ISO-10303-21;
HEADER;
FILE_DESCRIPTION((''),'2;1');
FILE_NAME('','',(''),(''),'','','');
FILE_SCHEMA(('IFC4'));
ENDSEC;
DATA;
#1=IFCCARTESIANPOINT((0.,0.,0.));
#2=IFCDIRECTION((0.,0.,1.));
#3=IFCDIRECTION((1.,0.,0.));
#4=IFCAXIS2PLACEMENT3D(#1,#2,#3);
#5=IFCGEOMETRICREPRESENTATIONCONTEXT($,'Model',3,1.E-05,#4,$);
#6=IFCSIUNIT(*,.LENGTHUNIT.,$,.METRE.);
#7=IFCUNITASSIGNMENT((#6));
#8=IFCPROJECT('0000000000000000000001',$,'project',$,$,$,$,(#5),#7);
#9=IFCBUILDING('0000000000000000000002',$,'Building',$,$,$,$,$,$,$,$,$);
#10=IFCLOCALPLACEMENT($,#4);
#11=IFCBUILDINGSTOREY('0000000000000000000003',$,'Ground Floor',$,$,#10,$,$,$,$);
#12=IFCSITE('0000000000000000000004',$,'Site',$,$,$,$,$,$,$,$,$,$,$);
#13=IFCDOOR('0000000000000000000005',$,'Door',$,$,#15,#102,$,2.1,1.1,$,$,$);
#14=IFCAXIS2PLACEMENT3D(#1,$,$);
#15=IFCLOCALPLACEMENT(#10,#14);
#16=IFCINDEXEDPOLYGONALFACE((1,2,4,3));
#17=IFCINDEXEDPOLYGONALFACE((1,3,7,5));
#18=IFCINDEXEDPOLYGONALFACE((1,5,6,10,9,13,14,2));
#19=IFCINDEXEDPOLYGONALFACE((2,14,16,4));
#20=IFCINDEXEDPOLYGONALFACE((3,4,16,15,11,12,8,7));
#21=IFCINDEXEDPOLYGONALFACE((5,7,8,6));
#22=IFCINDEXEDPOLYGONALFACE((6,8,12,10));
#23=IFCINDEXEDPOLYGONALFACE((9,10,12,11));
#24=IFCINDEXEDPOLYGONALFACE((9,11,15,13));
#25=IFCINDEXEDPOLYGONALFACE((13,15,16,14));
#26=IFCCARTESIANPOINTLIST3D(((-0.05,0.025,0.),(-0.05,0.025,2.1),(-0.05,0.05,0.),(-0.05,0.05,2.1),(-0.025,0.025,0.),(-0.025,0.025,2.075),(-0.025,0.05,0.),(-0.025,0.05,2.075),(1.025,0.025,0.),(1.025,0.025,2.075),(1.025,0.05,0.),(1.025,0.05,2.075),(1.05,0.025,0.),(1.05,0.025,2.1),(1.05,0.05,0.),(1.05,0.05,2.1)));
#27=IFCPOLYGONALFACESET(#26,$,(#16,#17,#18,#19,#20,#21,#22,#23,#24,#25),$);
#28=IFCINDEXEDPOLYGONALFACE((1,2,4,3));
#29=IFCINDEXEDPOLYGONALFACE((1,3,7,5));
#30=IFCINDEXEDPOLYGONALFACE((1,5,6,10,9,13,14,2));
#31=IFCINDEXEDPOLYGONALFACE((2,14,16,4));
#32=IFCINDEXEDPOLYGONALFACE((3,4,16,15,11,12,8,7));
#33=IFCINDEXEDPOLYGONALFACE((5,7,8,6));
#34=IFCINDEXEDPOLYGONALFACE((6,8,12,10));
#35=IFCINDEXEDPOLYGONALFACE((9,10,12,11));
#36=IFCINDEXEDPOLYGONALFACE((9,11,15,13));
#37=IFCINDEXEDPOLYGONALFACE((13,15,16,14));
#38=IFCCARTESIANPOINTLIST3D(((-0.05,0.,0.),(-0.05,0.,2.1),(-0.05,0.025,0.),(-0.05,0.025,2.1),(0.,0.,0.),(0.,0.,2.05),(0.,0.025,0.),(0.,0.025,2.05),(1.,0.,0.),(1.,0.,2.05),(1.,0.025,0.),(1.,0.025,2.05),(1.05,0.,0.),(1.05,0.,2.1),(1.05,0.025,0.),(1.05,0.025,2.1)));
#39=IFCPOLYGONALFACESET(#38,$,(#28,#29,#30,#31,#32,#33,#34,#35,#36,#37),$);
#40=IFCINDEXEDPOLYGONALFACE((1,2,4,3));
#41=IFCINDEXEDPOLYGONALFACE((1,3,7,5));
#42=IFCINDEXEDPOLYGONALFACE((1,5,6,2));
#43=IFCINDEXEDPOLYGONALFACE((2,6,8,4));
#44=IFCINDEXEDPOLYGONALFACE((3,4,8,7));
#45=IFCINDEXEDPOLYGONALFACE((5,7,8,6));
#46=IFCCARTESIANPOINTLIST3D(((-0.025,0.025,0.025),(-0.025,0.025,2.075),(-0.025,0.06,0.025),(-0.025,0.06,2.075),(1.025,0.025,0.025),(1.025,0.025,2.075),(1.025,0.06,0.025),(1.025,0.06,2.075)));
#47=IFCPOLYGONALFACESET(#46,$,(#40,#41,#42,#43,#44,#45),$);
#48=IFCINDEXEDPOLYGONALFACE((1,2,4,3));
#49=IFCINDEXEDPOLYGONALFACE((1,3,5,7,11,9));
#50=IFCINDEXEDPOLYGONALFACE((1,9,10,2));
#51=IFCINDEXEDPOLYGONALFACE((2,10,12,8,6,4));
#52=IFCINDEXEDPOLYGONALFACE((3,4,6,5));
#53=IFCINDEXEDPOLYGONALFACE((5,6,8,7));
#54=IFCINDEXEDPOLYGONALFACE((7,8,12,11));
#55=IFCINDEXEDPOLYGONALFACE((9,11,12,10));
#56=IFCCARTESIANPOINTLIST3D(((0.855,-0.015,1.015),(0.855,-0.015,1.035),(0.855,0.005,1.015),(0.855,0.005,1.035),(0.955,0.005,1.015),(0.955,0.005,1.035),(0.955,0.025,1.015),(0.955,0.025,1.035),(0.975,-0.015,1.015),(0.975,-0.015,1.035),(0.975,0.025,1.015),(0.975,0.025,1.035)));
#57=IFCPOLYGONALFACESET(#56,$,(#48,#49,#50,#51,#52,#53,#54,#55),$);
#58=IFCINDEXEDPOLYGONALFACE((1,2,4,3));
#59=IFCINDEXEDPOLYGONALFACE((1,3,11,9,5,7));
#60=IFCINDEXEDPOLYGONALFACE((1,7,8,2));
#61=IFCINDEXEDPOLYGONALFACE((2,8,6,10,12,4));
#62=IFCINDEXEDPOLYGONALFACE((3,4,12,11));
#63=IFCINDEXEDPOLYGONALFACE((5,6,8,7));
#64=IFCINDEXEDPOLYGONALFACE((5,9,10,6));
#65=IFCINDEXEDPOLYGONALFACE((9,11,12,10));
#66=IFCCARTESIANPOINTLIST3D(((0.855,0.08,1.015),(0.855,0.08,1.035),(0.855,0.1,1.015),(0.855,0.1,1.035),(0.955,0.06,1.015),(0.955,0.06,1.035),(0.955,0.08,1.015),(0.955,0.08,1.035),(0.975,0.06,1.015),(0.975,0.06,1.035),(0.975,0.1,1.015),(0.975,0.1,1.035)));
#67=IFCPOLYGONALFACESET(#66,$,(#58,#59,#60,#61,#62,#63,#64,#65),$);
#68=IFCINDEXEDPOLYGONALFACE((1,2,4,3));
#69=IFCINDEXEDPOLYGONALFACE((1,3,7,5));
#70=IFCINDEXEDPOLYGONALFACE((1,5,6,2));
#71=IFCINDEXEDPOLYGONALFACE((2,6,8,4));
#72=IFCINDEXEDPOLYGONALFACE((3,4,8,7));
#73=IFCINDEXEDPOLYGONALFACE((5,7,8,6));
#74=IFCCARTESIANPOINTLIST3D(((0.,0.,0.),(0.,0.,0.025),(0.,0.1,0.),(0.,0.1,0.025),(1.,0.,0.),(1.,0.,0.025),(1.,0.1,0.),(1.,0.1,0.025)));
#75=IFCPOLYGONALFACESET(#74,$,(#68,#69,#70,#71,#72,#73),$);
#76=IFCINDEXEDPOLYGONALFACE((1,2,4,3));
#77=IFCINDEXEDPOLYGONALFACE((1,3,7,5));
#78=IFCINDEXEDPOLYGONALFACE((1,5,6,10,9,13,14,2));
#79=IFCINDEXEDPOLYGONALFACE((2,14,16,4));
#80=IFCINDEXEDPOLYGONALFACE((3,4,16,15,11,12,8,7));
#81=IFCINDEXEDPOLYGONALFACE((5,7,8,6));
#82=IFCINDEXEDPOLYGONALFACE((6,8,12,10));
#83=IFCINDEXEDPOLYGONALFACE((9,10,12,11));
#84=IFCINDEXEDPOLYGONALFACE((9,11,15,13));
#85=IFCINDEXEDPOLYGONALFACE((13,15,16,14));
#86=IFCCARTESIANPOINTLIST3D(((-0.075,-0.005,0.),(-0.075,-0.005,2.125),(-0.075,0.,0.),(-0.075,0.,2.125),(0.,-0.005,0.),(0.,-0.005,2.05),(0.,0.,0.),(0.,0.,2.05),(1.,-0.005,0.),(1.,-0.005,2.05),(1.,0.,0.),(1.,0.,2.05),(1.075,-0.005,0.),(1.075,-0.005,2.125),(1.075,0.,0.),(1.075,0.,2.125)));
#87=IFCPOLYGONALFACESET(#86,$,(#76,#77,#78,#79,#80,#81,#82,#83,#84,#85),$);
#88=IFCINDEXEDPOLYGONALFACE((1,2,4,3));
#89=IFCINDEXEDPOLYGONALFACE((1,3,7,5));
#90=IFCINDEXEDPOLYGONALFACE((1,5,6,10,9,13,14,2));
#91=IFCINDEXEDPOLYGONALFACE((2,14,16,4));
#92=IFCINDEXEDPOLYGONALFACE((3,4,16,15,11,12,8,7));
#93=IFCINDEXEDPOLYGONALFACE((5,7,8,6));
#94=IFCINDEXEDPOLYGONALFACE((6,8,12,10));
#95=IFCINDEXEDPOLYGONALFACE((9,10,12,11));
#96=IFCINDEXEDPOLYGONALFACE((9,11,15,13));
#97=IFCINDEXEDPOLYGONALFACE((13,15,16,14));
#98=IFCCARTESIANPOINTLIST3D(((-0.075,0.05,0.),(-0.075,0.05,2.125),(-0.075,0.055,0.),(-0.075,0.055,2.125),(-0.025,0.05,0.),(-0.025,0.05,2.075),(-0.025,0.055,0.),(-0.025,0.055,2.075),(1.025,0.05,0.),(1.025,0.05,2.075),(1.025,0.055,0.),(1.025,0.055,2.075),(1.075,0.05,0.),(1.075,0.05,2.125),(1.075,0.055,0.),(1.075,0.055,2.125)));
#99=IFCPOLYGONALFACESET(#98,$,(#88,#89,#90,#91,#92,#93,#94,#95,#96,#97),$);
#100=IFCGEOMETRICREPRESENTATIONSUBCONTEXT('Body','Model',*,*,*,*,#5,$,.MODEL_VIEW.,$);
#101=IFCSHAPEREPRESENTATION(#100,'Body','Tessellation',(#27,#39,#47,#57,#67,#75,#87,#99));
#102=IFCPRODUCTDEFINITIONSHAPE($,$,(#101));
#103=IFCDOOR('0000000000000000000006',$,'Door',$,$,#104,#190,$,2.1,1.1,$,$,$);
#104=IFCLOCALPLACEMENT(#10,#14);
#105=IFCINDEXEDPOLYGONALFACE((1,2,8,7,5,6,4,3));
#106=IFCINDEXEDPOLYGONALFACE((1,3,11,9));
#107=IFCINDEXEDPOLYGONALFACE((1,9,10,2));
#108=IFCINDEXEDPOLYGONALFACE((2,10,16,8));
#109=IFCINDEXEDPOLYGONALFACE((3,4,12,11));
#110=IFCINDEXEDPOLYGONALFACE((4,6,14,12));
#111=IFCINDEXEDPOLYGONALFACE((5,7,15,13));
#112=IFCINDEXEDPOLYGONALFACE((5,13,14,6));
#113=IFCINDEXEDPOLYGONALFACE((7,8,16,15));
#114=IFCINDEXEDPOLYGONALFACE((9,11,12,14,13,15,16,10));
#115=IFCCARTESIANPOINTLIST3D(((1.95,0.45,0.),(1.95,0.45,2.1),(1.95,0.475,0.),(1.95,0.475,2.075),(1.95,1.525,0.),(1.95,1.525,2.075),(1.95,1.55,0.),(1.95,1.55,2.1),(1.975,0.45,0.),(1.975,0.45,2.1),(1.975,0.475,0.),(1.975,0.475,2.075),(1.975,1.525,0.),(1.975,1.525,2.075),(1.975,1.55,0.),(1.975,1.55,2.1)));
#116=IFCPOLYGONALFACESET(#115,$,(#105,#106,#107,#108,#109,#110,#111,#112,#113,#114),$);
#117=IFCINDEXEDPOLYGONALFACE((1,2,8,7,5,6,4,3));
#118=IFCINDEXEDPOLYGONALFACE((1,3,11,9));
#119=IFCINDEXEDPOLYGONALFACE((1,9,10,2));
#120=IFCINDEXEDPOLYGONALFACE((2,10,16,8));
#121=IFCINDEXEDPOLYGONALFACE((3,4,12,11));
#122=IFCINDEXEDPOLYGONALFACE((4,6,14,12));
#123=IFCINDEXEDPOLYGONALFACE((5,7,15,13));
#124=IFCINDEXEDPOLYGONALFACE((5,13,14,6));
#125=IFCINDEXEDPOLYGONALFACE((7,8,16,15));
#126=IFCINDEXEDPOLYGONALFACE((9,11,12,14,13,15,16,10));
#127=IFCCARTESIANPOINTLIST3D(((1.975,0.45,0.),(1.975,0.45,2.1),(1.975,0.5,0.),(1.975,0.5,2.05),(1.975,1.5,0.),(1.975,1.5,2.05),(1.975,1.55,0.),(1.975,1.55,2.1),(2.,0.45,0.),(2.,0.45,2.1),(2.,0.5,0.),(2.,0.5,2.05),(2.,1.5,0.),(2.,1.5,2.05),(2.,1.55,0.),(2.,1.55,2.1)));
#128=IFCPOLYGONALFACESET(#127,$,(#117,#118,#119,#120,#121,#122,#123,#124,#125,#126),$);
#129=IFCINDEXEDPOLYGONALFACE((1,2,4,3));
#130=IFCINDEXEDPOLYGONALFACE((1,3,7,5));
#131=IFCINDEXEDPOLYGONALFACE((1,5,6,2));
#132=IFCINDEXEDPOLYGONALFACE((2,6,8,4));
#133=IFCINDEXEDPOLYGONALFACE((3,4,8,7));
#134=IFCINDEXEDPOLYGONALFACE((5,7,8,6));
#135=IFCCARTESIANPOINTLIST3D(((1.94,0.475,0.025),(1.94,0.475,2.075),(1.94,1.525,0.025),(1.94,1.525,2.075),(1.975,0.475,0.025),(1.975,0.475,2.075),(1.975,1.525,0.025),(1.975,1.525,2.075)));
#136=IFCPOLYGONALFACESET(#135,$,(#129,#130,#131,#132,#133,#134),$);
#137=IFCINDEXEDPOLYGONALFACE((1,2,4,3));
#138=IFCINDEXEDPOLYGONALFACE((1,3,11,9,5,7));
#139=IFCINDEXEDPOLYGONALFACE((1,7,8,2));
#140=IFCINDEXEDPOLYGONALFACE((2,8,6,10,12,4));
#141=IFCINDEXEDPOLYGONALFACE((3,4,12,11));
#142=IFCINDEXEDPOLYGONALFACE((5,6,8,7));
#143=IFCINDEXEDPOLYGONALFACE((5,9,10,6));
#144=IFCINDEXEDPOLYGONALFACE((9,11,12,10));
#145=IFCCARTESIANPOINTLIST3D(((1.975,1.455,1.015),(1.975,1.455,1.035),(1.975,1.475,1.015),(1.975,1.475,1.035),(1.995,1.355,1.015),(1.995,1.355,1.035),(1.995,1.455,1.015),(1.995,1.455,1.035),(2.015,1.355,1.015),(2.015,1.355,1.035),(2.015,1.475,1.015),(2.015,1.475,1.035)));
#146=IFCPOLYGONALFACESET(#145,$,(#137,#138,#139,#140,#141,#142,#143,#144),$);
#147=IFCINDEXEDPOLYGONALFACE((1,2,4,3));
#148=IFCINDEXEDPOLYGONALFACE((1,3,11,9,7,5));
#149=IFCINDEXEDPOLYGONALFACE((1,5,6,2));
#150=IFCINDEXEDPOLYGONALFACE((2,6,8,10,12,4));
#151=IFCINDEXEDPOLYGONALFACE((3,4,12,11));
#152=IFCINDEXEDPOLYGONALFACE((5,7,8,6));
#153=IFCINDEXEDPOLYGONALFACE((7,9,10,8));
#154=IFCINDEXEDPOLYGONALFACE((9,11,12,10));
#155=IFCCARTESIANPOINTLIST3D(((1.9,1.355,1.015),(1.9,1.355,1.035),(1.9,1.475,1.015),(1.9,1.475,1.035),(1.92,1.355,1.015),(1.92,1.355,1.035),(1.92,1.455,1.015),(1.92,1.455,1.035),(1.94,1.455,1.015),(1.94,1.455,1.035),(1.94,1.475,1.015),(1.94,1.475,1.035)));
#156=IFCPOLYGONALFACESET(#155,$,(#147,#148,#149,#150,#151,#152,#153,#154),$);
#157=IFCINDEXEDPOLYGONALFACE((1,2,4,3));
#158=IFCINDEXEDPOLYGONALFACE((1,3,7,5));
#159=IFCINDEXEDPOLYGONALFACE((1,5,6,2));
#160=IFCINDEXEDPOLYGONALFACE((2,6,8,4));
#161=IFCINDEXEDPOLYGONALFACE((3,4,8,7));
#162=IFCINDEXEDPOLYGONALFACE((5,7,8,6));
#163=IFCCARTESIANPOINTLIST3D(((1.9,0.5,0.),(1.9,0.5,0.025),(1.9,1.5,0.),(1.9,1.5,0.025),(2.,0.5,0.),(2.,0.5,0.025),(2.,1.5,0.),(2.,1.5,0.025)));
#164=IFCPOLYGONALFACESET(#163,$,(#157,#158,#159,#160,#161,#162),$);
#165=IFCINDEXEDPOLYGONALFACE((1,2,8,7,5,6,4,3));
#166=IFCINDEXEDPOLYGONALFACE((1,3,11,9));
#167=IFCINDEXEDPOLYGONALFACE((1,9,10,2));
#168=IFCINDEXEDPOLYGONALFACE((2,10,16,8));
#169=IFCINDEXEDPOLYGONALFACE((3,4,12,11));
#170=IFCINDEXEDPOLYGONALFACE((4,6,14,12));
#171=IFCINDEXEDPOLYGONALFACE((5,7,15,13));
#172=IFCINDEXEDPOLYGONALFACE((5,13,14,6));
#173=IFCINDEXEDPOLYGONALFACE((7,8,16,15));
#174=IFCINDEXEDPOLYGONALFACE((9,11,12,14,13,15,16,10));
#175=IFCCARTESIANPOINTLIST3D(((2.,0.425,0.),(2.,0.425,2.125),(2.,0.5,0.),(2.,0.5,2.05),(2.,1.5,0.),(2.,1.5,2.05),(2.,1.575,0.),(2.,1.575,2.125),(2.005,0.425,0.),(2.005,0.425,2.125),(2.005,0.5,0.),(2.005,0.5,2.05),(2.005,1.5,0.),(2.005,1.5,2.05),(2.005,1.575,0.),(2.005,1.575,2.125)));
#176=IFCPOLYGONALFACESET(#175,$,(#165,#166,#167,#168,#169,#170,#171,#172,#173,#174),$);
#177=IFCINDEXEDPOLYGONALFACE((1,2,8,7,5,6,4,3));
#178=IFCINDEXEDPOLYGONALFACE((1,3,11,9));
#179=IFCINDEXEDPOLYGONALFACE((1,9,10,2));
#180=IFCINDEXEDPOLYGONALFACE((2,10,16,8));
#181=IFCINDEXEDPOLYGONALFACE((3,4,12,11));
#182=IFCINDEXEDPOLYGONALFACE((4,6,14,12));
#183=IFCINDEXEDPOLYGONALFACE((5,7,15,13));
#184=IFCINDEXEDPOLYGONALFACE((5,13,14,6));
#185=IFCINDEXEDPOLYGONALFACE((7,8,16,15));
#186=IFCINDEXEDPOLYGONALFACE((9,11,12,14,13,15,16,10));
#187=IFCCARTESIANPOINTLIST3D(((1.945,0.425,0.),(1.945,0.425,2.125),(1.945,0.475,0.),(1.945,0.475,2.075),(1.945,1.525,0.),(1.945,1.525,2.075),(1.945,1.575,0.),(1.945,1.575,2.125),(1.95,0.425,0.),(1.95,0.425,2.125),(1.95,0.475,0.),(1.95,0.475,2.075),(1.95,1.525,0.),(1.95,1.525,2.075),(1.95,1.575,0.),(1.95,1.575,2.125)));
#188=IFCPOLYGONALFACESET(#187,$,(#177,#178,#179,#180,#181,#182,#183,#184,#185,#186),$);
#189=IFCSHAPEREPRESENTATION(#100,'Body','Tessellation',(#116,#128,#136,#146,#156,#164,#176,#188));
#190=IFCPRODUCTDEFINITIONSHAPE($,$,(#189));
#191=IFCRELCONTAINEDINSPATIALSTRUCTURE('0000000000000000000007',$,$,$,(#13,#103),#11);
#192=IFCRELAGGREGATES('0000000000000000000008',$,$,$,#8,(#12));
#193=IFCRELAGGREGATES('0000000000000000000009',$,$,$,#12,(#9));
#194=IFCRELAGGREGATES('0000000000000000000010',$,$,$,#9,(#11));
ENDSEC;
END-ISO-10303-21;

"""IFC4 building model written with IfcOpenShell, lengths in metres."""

from ifc_helpers import new_model, si_unit, frame, origin_with_axes, place, context, subcontext, project, spatial, line, indexed_curve, outline, extrude, element, save


model = new_model("IFC4")

# Units and contexts
model_context = context("Model", 3, precision=1e-05, world=origin_with_axes())
body_context = subcontext(model_context, "Body", "Model", "MODEL_VIEW")
ifc_project = project(units=[si_unit("LENGTHUNIT", "METRE")], contexts=[model_context])

# Site, building, storey
site = spatial("IfcSite", under=ifc_project, Name="Site")
building = spatial("IfcBuilding", under=site, Name="Building")
storey_placement = place(None, origin_with_axes())
storey = spatial("IfcBuildingStorey", under=building, at=storey_placement, Name="Ground Floor")

# Doors
door_1_placement = place(storey_placement, frame((-0.05, 0.0, 0.0), z_axis=(0.0, 0.0, 1.0), x_axis=(1.0, 0.0, 0.0)))
element("IfcDoor", 1, at=door_1_placement, inside=storey, Name="Door", OverallHeight=2.1, OverallWidth=1.1, context=body_context, shape_type="SweptSolid", body=[
    extrude(outline(indexed_curve([(0.0, 0.0), (0.0, 2.1), (1.1, 2.1), (1.1, 0.0), (1.075, 0.0), (1.075, 2.075), (0.025, 2.075), (0.025, 0.0)], segments=[line(1, 2, 3, 4, 5, 6, 7, 8, 1)])), frame((0.0, 0.025, 0.0), z_axis=(0.0, -1.0, 0.0), x_axis=(1.0, 0.0, 0.0)), (0.0, 0.0, -1.0), 0.025),
    extrude(outline(indexed_curve([(0.0, 0.0), (0.0, 2.1), (1.1, 2.1), (1.1, 0.0), (1.05, 0.0), (1.05, 2.05), (0.05, 2.05), (0.05, 0.0)], segments=[line(1, 2, 3, 4, 5, 6, 7, 8, 1)])), frame((0.0, 0.0, 0.0), z_axis=(0.0, -1.0, 0.0), x_axis=(1.0, 0.0, 0.0)), (0.0, 0.0, -1.0), 0.025),
    extrude(outline(indexed_curve([(0.0, 0.0), (1.05, 0.0), (1.05, 0.035), (0.0, 0.035)], segments=[line(1, 2, 3, 4, 1)])), frame((0.025, 0.025, 0.025), z_axis=(0.0, 0.0, 1.0), x_axis=(1.0, 0.0, 0.0)), (0.0, 0.0, 1.0), 2.05),
    extrude(outline(indexed_curve([(0.0, 0.0), (0.0, -0.04), (-0.12, -0.04), (-0.12, -0.02), (-0.02, -0.02), (-0.02, 0.0)], segments=[line(1, 2, 3, 4, 5, 6, 1)])), frame((1.025, 0.025, 1.015), z_axis=(0.0, 0.0, 1.0), x_axis=(1.0, 0.0, 0.0)), (0.0, 0.0, 1.0), 0.02),
    extrude(outline(indexed_curve([(0.0, 0.0), (0.0, 0.04), (-0.12, 0.04), (-0.12, 0.02), (-0.02, 0.02), (-0.02, 0.0)], segments=[line(1, 2, 3, 4, 5, 6, 1)])), frame((1.025, 0.06, 1.015), z_axis=(0.0, 0.0, 1.0), x_axis=(1.0, 0.0, 0.0)), (0.0, 0.0, 1.0), 0.02),
    extrude(outline(indexed_curve([(0.0, 0.0), (1.0, 0.0), (1.0, 0.1), (0.0, 0.1)], segments=[line(1, 2, 3, 4, 1)])), frame((0.05, 0.0, 0.0), z_axis=(0.0, 0.0, 1.0), x_axis=(1.0, 0.0, 0.0)), (0.0, 0.0, 1.0), 0.025),
    extrude(outline(indexed_curve([(0.0, 0.0), (0.0, 2.125), (1.15, 2.125), (1.15, 0.0), (1.075, 0.0), (1.075, 2.05), (0.075, 2.05), (0.075, 0.0)], segments=[line(1, 2, 3, 4, 5, 6, 7, 8, 1)])), frame((-0.025, -0.005, 0.0), z_axis=(0.0, -1.0, 0.0), x_axis=(1.0, 0.0, 0.0)), (0.0, 0.0, -1.0), 0.005),
    extrude(outline(indexed_curve([(0.0, 0.0), (0.0, 2.125), (1.15, 2.125), (1.15, 0.0), (1.1, 0.0), (1.1, 2.075), (0.05, 2.075), (0.05, 0.0)], segments=[line(1, 2, 3, 4, 5, 6, 7, 8, 1)])), frame((-0.025, 0.05, 0.0), z_axis=(0.0, -1.0, 0.0), x_axis=(1.0, 0.0, 0.0)), (0.0, 0.0, -1.0), 0.005),
])
door_2_placement = place(storey_placement, frame((2.0, 0.45, 0.0), z_axis=(0.0, 0.0, 1.0), x_axis=(0.0, 1.0, 0.0)))
element("IfcDoor", 2, at=door_2_placement, inside=storey, Name="Door", OverallHeight=2.1, OverallWidth=1.1, context=body_context, shape_type="SweptSolid", body=[
    extrude(outline(indexed_curve([(0.0, 0.0), (0.0, 2.1), (1.1, 2.1), (1.1, 0.0), (1.075, 0.0), (1.075, 2.075), (0.025, 2.075), (0.025, 0.0)], segments=[line(1, 2, 3, 4, 5, 6, 7, 8, 1)])), frame((0.0, 0.025, 0.0), z_axis=(0.0, -1.0, 0.0), x_axis=(1.0, 0.0, 0.0)), (0.0, 0.0, -1.0), 0.025),
    extrude(outline(indexed_curve([(0.0, 0.0), (0.0, 2.1), (1.1, 2.1), (1.1, 0.0), (1.05, 0.0), (1.05, 2.05), (0.05, 2.05), (0.05, 0.0)], segments=[line(1, 2, 3, 4, 5, 6, 7, 8, 1)])), frame((0.0, 0.0, 0.0), z_axis=(0.0, -1.0, 0.0), x_axis=(1.0, 0.0, 0.0)), (0.0, 0.0, -1.0), 0.025),
    extrude(outline(indexed_curve([(0.0, 0.0), (1.05, 0.0), (1.05, 0.035), (0.0, 0.035)], segments=[line(1, 2, 3, 4, 1)])), frame((0.025, 0.025, 0.025), z_axis=(0.0, 0.0, 1.0), x_axis=(1.0, 0.0, 0.0)), (0.0, 0.0, 1.0), 2.05),
    extrude(outline(indexed_curve([(0.0, 0.0), (0.0, -0.04), (-0.12, -0.04), (-0.12, -0.02), (-0.02, -0.02), (-0.02, 0.0)], segments=[line(1, 2, 3, 4, 5, 6, 1)])), frame((1.025, 0.025, 1.015), z_axis=(0.0, 0.0, 1.0), x_axis=(1.0, 0.0, 0.0)), (0.0, 0.0, 1.0), 0.02),
    extrude(outline(indexed_curve([(0.0, 0.0), (0.0, 0.04), (-0.12, 0.04), (-0.12, 0.02), (-0.02, 0.02), (-0.02, 0.0)], segments=[line(1, 2, 3, 4, 5, 6, 1)])), frame((1.025, 0.06, 1.015), z_axis=(0.0, 0.0, 1.0), x_axis=(1.0, 0.0, 0.0)), (0.0, 0.0, 1.0), 0.02),
    extrude(outline(indexed_curve([(0.0, 0.0), (1.0, 0.0), (1.0, 0.1), (0.0, 0.1)], segments=[line(1, 2, 3, 4, 1)])), frame((0.05, 0.0, 0.0), z_axis=(0.0, 0.0, 1.0), x_axis=(1.0, 0.0, 0.0)), (0.0, 0.0, 1.0), 0.025),
    extrude(outline(indexed_curve([(0.0, 0.0), (0.0, 2.125), (1.15, 2.125), (1.15, 0.0), (1.075, 0.0), (1.075, 2.05), (0.075, 2.05), (0.075, 0.0)], segments=[line(1, 2, 3, 4, 5, 6, 7, 8, 1)])), frame((-0.025, -0.005, 0.0), z_axis=(0.0, -1.0, 0.0), x_axis=(1.0, 0.0, 0.0)), (0.0, 0.0, -1.0), 0.005),
    extrude(outline(indexed_curve([(0.0, 0.0), (0.0, 2.125), (1.15, 2.125), (1.15, 0.0), (1.1, 0.0), (1.1, 2.075), (0.05, 2.075), (0.05, 0.0)], segments=[line(1, 2, 3, 4, 5, 6, 7, 8, 1)])), frame((-0.025, 0.05, 0.0), z_axis=(0.0, -1.0, 0.0), x_axis=(1.0, 0.0, 0.0)), (0.0, 0.0, -1.0), 0.005),
])

save(model, "model.ifc")
